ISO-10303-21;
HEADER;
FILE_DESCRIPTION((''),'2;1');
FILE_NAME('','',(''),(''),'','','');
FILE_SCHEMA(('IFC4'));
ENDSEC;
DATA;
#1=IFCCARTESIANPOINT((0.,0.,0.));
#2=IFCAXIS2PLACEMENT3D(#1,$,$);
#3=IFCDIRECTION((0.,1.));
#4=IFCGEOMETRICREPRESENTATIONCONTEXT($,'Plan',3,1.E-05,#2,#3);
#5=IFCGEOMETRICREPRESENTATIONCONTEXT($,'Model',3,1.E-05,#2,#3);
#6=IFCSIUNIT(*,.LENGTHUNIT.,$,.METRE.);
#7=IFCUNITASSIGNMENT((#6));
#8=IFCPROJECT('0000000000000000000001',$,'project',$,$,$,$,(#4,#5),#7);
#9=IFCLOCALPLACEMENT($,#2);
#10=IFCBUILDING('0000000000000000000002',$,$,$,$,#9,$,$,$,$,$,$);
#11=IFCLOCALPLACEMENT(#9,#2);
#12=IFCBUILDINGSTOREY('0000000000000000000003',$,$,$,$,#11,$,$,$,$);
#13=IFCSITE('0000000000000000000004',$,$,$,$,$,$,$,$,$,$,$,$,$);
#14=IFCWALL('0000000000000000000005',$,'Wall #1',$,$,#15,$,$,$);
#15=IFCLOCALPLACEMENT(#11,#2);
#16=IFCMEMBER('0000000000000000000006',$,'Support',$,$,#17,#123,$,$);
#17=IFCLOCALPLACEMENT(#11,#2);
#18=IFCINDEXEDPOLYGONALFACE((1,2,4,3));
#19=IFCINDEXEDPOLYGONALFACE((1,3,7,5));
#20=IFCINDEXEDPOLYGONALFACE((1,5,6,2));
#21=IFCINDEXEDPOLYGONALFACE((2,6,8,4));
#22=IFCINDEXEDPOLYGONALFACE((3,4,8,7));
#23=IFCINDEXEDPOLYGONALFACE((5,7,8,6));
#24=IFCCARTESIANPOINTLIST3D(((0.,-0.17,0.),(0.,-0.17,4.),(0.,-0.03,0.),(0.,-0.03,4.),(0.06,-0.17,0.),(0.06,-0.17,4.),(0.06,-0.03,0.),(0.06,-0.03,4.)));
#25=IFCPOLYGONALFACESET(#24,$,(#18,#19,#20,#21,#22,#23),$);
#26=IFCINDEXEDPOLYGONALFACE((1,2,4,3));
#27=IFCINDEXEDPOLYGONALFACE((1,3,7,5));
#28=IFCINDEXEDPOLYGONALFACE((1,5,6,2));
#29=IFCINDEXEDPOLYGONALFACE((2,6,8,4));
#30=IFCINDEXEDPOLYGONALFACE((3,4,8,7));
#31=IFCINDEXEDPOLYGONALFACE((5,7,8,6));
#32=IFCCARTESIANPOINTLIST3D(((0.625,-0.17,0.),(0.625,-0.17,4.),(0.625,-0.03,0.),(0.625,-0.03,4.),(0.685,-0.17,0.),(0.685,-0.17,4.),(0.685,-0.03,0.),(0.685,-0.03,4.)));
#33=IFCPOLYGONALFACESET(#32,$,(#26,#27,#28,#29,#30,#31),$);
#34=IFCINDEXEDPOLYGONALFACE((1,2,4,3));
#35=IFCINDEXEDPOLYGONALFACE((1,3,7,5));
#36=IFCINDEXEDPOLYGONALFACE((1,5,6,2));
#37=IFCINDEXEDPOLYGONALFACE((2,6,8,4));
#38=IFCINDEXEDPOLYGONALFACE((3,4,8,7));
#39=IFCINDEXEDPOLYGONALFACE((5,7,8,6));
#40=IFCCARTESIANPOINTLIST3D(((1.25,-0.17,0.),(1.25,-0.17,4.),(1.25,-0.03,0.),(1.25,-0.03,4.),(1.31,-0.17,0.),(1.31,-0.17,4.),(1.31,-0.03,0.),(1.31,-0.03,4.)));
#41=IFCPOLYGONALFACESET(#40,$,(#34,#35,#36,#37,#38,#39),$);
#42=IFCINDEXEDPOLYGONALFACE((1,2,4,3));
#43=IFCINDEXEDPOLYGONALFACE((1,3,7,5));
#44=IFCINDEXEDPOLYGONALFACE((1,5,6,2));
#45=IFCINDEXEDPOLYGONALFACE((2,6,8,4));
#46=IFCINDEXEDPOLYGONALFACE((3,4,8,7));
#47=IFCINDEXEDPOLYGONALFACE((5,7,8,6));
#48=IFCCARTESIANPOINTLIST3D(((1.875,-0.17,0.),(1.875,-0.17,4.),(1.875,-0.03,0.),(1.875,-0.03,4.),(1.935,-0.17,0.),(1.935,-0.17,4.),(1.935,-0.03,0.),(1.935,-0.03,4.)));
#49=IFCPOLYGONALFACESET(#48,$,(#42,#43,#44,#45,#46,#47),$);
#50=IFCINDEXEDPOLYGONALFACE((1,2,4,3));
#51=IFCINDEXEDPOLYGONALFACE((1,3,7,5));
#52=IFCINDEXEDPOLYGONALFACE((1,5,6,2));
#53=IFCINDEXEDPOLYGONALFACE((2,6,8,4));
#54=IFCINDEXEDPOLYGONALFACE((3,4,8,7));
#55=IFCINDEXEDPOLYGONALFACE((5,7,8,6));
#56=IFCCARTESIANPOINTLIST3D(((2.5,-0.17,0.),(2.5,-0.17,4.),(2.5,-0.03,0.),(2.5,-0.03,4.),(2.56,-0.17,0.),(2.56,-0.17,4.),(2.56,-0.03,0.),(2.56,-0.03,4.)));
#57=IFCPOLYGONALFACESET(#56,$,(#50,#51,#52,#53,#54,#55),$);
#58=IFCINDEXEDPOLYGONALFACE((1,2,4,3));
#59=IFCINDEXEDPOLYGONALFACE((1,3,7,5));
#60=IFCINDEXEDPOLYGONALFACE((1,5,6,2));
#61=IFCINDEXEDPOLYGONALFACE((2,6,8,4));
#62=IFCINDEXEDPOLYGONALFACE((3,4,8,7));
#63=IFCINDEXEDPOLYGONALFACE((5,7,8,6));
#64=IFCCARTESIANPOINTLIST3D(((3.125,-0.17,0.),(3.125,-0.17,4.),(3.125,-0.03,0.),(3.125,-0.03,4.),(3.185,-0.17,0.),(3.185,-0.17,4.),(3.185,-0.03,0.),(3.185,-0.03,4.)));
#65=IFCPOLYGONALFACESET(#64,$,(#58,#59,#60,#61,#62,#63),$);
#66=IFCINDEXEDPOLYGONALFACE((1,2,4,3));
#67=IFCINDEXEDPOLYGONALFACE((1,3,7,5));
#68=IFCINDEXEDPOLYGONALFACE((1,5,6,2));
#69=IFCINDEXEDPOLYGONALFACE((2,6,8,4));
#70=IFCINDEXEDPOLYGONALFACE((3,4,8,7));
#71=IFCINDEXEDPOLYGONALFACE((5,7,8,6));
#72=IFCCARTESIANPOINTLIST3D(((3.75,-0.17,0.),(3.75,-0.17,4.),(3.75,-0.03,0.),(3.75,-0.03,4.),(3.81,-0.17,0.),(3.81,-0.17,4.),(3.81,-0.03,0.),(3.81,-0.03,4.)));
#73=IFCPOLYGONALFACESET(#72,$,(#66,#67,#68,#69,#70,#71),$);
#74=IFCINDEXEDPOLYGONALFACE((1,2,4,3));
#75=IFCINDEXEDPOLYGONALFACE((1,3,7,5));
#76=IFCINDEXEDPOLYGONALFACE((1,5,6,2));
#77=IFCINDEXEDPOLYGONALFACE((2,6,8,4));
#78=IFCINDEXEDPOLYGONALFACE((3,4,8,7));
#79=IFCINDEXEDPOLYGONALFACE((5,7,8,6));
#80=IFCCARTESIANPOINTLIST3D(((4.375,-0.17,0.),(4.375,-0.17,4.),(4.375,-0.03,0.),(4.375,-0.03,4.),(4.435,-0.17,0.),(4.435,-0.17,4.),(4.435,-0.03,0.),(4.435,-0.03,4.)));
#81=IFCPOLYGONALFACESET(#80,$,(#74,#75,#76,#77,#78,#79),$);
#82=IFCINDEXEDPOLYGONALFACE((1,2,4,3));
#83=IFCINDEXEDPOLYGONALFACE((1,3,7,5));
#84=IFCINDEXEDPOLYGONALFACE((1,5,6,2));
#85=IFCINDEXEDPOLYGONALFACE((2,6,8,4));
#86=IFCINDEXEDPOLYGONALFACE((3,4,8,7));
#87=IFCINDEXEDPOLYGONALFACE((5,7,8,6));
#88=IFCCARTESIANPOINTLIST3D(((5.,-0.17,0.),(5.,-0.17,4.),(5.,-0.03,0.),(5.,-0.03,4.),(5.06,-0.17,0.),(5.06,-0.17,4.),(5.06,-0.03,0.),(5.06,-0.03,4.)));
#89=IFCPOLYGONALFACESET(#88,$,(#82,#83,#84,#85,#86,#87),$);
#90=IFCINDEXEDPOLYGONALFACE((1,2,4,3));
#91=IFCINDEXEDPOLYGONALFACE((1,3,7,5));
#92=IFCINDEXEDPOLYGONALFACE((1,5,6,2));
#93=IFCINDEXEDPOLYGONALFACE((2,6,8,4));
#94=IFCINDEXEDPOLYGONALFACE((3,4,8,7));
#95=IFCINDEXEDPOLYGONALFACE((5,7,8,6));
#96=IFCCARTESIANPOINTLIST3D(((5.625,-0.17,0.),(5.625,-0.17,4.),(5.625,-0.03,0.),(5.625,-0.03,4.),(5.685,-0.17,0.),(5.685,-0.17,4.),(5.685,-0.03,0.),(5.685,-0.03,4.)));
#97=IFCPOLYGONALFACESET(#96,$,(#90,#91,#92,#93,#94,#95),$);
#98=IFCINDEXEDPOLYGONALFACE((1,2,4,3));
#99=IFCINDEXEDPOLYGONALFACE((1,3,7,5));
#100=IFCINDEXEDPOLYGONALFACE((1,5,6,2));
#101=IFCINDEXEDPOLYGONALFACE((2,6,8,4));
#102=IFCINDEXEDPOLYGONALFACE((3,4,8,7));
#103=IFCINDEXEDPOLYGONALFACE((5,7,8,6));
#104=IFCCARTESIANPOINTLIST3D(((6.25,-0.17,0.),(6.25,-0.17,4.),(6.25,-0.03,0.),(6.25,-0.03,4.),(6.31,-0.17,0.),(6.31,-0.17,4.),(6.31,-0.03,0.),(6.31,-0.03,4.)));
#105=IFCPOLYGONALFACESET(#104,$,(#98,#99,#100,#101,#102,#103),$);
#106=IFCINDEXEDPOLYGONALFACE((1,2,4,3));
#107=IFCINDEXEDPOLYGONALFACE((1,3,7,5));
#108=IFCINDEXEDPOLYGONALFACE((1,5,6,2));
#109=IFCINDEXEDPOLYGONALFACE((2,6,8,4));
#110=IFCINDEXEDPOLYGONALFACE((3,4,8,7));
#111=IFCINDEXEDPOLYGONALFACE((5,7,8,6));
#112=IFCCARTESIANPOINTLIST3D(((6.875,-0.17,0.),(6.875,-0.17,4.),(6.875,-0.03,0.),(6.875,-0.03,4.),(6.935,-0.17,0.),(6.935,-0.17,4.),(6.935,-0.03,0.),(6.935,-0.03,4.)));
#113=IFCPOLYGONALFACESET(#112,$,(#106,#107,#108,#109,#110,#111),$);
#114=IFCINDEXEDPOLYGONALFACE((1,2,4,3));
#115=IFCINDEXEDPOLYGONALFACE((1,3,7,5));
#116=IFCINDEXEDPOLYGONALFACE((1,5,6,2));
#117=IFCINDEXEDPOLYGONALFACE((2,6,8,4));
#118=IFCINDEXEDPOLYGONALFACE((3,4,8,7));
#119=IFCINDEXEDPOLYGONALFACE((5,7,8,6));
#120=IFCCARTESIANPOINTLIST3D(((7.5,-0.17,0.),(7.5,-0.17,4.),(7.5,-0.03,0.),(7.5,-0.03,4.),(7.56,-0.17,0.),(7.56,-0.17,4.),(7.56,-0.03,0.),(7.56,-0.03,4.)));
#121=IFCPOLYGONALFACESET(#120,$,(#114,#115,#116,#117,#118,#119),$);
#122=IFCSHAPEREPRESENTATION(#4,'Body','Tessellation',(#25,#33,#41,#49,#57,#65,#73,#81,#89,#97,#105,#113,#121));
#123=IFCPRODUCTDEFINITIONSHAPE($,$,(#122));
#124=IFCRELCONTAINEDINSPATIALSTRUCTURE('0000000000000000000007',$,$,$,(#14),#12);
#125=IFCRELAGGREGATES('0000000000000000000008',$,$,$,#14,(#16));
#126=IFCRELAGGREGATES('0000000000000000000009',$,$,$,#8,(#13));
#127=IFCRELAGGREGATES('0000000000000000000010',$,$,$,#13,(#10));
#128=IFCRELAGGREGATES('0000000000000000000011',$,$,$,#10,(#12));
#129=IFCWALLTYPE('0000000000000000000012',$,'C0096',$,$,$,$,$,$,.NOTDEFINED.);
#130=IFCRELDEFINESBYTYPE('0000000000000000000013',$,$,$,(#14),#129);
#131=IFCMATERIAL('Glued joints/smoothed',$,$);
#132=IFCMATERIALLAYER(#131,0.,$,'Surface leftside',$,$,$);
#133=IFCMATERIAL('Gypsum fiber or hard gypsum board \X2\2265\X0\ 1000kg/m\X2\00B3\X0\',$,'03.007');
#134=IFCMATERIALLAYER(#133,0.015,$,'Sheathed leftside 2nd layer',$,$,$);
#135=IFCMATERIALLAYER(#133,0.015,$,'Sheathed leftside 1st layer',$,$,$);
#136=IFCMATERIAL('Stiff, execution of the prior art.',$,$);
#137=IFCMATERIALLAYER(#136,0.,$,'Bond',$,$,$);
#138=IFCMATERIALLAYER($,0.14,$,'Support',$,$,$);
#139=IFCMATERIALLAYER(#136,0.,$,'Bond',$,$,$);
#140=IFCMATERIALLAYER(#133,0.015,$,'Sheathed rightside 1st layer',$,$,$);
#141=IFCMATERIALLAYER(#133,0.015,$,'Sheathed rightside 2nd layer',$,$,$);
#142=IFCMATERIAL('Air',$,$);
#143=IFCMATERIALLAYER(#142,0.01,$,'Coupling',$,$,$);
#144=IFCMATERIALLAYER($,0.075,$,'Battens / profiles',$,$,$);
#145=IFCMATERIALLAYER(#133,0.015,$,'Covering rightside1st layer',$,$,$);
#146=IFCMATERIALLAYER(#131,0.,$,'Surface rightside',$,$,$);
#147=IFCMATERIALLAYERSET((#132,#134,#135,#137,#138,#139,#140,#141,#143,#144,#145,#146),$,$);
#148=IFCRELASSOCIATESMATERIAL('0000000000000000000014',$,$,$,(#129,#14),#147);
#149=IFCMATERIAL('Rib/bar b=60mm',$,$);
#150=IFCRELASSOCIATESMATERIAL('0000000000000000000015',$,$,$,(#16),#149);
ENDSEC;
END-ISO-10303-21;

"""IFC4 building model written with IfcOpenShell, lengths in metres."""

from ifc_helpers import new_model, si_unit, direction, frame, frame_2d, origin, place, context, project, spatial, rectangle, extrude, material, layer, layer_set, type_object, element, aggregate, save


model = new_model("IFC4")

# Units and contexts
plan_context = context("Plan", 3, precision=1e-05, world=origin(), true_north=direction((0.0, 1.0)))
model_context = context("Model", 3, precision=1e-05, world=origin(), true_north=direction((0.0, 1.0)))
ifc_project = project(units=[si_unit("LENGTHUNIT", "METRE")], contexts=[plan_context, model_context])

# Site, building, storey
site = spatial("IfcSite", under=ifc_project)
building_placement = place(None, origin())
building = spatial("IfcBuilding", under=site, at=building_placement)
storey_placement = place(building_placement, origin())
storey = spatial("IfcBuildingStorey", under=building, at=storey_placement)

# Wall, member
ifc_material_1 = material(Name="Glued joints/smoothed")
ifc_layer_1 = layer(ifc_material_1, 0.0, Name="Surface leftside")
ifc_material_2 = material(Name="Gypsum fiber or hard gypsum board ≥ 1000kg/m³", Category="03.007")
ifc_layer_2 = layer(ifc_material_2, 0.015, Name="Sheathed leftside 2nd layer")
ifc_layer_3 = layer(ifc_material_2, 0.015, Name="Sheathed leftside 1st layer")
ifc_material_3 = material(Name="Stiff, execution of the prior art.")
ifc_layer_4 = layer(ifc_material_3, 0.0, Name="Bond")
ifc_layer_5 = layer(None, 0.14, Name="Support")
ifc_layer_6 = layer(ifc_material_3, 0.0, Name="Bond")
ifc_layer_7 = layer(ifc_material_2, 0.015, Name="Sheathed rightside 1st layer")
ifc_layer_8 = layer(ifc_material_2, 0.015, Name="Sheathed rightside 2nd layer")
ifc_material_4 = material(Name="Air")
ifc_layer_9 = layer(ifc_material_4, 0.01, Name="Coupling")
ifc_layer_10 = layer(None, 0.075, Name="Battens / profiles")
ifc_layer_11 = layer(ifc_material_2, 0.015, Name="Covering rightside1st layer")
ifc_layer_12 = layer(ifc_material_1, 0.0, Name="Surface rightside")
ifc_layer_set = layer_set([ifc_layer_1, ifc_layer_2, ifc_layer_3, ifc_layer_4, ifc_layer_5, ifc_layer_6, ifc_layer_7, ifc_layer_8, ifc_layer_9, ifc_layer_10, ifc_layer_11, ifc_layer_12])
wall_type = type_object("IfcWallType", Name="C0096", PredefinedType="NOTDEFINED", material=ifc_layer_set)
wall_placement = place(None, frame((0.0, 0.0, 0.0), z_axis=(0.0, -1.0, 0.0), x_axis=(1.0, 0.0, 0.0)))
wall = element("IfcWall", 1, at=wall_placement, inside=storey, type_object=wall_type, material=ifc_layer_set, Name="Wall #1")
ifc_material_5 = material(Name="Rib/bar b=60mm")
member_1_placement = place(wall_placement, origin())
member_1 = element("IfcMember", 2, at=member_1_placement, material=ifc_material_5, Name="Support", context=plan_context, shape_type="SweptSolid", body=[
    extrude(rectangle(XDim=0.06, YDim=0.14, at=frame_2d((0.03, 0.07), x_axis=(1.0, 0.0))), frame((0.0, 4.0, 0.03), z_axis=(0.0, -1.0, 0.0), x_axis=(1.0, 0.0, 0.0)), (0.0, 0.0, 1.0), 4.0),
    extrude(rectangle(XDim=0.06, YDim=0.14, at=frame_2d((0.03, 0.07), x_axis=(1.0, 0.0))), frame((0.625, 4.0, 0.03), z_axis=(0.0, -1.0, 0.0), x_axis=(1.0, 0.0, 0.0)), (0.0, 0.0, 1.0), 4.0),
    extrude(rectangle(XDim=0.06, YDim=0.14, at=frame_2d((0.03, 0.07), x_axis=(1.0, 0.0))), frame((1.25, 4.0, 0.03), z_axis=(0.0, -1.0, 0.0), x_axis=(1.0, 0.0, 0.0)), (0.0, 0.0, 1.0), 4.0),
    extrude(rectangle(XDim=0.06, YDim=0.14, at=frame_2d((0.03, 0.07), x_axis=(1.0, 0.0))), frame((1.875, 4.0, 0.03), z_axis=(0.0, -1.0, 0.0), x_axis=(1.0, 0.0, 0.0)), (0.0, 0.0, 1.0), 4.0),
    extrude(rectangle(XDim=0.06, YDim=0.14, at=frame_2d((0.03, 0.07), x_axis=(1.0, 0.0))), frame((2.5, 4.0, 0.03), z_axis=(0.0, -1.0, 0.0), x_axis=(1.0, 0.0, 0.0)), (0.0, 0.0, 1.0), 4.0),
    extrude(rectangle(XDim=0.06, YDim=0.14, at=frame_2d((0.03, 0.07), x_axis=(1.0, 0.0))), frame((3.125, 4.0, 0.03), z_axis=(0.0, -1.0, 0.0), x_axis=(1.0, 0.0, 0.0)), (0.0, 0.0, 1.0), 4.0),
    extrude(rectangle(XDim=0.06, YDim=0.14, at=frame_2d((0.03, 0.07), x_axis=(1.0, 0.0))), frame((3.75, 4.0, 0.03), z_axis=(0.0, -1.0, 0.0), x_axis=(1.0, 0.0, 0.0)), (0.0, 0.0, 1.0), 4.0),
    extrude(rectangle(XDim=0.06, YDim=0.14, at=frame_2d((0.03, 0.07), x_axis=(1.0, 0.0))), frame((4.375, 4.0, 0.03), z_axis=(0.0, -1.0, 0.0), x_axis=(1.0, 0.0, 0.0)), (0.0, 0.0, 1.0), 4.0),
    extrude(rectangle(XDim=0.06, YDim=0.14, at=frame_2d((0.03, 0.07), x_axis=(1.0, 0.0))), frame((5.0, 4.0, 0.03), z_axis=(0.0, -1.0, 0.0), x_axis=(1.0, 0.0, 0.0)), (0.0, 0.0, 1.0), 4.0),
    extrude(rectangle(XDim=0.06, YDim=0.14, at=frame_2d((0.03, 0.07), x_axis=(1.0, 0.0))), frame((5.625, 4.0, 0.03), z_axis=(0.0, -1.0, 0.0), x_axis=(1.0, 0.0, 0.0)), (0.0, 0.0, 1.0), 4.0),
    extrude(rectangle(XDim=0.06, YDim=0.14, at=frame_2d((0.03, 0.07), x_axis=(1.0, 0.0))), frame((6.25, 4.0, 0.03), z_axis=(0.0, -1.0, 0.0), x_axis=(1.0, 0.0, 0.0)), (0.0, 0.0, 1.0), 4.0),
    extrude(rectangle(XDim=0.06, YDim=0.14, at=frame_2d((0.03, 0.07), x_axis=(1.0, 0.0))), frame((6.875, 4.0, 0.03), z_axis=(0.0, -1.0, 0.0), x_axis=(1.0, 0.0, 0.0)), (0.0, 0.0, 1.0), 4.0),
    extrude(rectangle(XDim=0.06, YDim=0.14, at=frame_2d((0.03, 0.07), x_axis=(1.0, 0.0))), frame((7.5, 4.0, 0.03), z_axis=(0.0, -1.0, 0.0), x_axis=(1.0, 0.0, 0.0)), (0.0, 0.0, 1.0), 4.0),
])
aggregate(wall, [member_1])

save(model, "model.ifc")
